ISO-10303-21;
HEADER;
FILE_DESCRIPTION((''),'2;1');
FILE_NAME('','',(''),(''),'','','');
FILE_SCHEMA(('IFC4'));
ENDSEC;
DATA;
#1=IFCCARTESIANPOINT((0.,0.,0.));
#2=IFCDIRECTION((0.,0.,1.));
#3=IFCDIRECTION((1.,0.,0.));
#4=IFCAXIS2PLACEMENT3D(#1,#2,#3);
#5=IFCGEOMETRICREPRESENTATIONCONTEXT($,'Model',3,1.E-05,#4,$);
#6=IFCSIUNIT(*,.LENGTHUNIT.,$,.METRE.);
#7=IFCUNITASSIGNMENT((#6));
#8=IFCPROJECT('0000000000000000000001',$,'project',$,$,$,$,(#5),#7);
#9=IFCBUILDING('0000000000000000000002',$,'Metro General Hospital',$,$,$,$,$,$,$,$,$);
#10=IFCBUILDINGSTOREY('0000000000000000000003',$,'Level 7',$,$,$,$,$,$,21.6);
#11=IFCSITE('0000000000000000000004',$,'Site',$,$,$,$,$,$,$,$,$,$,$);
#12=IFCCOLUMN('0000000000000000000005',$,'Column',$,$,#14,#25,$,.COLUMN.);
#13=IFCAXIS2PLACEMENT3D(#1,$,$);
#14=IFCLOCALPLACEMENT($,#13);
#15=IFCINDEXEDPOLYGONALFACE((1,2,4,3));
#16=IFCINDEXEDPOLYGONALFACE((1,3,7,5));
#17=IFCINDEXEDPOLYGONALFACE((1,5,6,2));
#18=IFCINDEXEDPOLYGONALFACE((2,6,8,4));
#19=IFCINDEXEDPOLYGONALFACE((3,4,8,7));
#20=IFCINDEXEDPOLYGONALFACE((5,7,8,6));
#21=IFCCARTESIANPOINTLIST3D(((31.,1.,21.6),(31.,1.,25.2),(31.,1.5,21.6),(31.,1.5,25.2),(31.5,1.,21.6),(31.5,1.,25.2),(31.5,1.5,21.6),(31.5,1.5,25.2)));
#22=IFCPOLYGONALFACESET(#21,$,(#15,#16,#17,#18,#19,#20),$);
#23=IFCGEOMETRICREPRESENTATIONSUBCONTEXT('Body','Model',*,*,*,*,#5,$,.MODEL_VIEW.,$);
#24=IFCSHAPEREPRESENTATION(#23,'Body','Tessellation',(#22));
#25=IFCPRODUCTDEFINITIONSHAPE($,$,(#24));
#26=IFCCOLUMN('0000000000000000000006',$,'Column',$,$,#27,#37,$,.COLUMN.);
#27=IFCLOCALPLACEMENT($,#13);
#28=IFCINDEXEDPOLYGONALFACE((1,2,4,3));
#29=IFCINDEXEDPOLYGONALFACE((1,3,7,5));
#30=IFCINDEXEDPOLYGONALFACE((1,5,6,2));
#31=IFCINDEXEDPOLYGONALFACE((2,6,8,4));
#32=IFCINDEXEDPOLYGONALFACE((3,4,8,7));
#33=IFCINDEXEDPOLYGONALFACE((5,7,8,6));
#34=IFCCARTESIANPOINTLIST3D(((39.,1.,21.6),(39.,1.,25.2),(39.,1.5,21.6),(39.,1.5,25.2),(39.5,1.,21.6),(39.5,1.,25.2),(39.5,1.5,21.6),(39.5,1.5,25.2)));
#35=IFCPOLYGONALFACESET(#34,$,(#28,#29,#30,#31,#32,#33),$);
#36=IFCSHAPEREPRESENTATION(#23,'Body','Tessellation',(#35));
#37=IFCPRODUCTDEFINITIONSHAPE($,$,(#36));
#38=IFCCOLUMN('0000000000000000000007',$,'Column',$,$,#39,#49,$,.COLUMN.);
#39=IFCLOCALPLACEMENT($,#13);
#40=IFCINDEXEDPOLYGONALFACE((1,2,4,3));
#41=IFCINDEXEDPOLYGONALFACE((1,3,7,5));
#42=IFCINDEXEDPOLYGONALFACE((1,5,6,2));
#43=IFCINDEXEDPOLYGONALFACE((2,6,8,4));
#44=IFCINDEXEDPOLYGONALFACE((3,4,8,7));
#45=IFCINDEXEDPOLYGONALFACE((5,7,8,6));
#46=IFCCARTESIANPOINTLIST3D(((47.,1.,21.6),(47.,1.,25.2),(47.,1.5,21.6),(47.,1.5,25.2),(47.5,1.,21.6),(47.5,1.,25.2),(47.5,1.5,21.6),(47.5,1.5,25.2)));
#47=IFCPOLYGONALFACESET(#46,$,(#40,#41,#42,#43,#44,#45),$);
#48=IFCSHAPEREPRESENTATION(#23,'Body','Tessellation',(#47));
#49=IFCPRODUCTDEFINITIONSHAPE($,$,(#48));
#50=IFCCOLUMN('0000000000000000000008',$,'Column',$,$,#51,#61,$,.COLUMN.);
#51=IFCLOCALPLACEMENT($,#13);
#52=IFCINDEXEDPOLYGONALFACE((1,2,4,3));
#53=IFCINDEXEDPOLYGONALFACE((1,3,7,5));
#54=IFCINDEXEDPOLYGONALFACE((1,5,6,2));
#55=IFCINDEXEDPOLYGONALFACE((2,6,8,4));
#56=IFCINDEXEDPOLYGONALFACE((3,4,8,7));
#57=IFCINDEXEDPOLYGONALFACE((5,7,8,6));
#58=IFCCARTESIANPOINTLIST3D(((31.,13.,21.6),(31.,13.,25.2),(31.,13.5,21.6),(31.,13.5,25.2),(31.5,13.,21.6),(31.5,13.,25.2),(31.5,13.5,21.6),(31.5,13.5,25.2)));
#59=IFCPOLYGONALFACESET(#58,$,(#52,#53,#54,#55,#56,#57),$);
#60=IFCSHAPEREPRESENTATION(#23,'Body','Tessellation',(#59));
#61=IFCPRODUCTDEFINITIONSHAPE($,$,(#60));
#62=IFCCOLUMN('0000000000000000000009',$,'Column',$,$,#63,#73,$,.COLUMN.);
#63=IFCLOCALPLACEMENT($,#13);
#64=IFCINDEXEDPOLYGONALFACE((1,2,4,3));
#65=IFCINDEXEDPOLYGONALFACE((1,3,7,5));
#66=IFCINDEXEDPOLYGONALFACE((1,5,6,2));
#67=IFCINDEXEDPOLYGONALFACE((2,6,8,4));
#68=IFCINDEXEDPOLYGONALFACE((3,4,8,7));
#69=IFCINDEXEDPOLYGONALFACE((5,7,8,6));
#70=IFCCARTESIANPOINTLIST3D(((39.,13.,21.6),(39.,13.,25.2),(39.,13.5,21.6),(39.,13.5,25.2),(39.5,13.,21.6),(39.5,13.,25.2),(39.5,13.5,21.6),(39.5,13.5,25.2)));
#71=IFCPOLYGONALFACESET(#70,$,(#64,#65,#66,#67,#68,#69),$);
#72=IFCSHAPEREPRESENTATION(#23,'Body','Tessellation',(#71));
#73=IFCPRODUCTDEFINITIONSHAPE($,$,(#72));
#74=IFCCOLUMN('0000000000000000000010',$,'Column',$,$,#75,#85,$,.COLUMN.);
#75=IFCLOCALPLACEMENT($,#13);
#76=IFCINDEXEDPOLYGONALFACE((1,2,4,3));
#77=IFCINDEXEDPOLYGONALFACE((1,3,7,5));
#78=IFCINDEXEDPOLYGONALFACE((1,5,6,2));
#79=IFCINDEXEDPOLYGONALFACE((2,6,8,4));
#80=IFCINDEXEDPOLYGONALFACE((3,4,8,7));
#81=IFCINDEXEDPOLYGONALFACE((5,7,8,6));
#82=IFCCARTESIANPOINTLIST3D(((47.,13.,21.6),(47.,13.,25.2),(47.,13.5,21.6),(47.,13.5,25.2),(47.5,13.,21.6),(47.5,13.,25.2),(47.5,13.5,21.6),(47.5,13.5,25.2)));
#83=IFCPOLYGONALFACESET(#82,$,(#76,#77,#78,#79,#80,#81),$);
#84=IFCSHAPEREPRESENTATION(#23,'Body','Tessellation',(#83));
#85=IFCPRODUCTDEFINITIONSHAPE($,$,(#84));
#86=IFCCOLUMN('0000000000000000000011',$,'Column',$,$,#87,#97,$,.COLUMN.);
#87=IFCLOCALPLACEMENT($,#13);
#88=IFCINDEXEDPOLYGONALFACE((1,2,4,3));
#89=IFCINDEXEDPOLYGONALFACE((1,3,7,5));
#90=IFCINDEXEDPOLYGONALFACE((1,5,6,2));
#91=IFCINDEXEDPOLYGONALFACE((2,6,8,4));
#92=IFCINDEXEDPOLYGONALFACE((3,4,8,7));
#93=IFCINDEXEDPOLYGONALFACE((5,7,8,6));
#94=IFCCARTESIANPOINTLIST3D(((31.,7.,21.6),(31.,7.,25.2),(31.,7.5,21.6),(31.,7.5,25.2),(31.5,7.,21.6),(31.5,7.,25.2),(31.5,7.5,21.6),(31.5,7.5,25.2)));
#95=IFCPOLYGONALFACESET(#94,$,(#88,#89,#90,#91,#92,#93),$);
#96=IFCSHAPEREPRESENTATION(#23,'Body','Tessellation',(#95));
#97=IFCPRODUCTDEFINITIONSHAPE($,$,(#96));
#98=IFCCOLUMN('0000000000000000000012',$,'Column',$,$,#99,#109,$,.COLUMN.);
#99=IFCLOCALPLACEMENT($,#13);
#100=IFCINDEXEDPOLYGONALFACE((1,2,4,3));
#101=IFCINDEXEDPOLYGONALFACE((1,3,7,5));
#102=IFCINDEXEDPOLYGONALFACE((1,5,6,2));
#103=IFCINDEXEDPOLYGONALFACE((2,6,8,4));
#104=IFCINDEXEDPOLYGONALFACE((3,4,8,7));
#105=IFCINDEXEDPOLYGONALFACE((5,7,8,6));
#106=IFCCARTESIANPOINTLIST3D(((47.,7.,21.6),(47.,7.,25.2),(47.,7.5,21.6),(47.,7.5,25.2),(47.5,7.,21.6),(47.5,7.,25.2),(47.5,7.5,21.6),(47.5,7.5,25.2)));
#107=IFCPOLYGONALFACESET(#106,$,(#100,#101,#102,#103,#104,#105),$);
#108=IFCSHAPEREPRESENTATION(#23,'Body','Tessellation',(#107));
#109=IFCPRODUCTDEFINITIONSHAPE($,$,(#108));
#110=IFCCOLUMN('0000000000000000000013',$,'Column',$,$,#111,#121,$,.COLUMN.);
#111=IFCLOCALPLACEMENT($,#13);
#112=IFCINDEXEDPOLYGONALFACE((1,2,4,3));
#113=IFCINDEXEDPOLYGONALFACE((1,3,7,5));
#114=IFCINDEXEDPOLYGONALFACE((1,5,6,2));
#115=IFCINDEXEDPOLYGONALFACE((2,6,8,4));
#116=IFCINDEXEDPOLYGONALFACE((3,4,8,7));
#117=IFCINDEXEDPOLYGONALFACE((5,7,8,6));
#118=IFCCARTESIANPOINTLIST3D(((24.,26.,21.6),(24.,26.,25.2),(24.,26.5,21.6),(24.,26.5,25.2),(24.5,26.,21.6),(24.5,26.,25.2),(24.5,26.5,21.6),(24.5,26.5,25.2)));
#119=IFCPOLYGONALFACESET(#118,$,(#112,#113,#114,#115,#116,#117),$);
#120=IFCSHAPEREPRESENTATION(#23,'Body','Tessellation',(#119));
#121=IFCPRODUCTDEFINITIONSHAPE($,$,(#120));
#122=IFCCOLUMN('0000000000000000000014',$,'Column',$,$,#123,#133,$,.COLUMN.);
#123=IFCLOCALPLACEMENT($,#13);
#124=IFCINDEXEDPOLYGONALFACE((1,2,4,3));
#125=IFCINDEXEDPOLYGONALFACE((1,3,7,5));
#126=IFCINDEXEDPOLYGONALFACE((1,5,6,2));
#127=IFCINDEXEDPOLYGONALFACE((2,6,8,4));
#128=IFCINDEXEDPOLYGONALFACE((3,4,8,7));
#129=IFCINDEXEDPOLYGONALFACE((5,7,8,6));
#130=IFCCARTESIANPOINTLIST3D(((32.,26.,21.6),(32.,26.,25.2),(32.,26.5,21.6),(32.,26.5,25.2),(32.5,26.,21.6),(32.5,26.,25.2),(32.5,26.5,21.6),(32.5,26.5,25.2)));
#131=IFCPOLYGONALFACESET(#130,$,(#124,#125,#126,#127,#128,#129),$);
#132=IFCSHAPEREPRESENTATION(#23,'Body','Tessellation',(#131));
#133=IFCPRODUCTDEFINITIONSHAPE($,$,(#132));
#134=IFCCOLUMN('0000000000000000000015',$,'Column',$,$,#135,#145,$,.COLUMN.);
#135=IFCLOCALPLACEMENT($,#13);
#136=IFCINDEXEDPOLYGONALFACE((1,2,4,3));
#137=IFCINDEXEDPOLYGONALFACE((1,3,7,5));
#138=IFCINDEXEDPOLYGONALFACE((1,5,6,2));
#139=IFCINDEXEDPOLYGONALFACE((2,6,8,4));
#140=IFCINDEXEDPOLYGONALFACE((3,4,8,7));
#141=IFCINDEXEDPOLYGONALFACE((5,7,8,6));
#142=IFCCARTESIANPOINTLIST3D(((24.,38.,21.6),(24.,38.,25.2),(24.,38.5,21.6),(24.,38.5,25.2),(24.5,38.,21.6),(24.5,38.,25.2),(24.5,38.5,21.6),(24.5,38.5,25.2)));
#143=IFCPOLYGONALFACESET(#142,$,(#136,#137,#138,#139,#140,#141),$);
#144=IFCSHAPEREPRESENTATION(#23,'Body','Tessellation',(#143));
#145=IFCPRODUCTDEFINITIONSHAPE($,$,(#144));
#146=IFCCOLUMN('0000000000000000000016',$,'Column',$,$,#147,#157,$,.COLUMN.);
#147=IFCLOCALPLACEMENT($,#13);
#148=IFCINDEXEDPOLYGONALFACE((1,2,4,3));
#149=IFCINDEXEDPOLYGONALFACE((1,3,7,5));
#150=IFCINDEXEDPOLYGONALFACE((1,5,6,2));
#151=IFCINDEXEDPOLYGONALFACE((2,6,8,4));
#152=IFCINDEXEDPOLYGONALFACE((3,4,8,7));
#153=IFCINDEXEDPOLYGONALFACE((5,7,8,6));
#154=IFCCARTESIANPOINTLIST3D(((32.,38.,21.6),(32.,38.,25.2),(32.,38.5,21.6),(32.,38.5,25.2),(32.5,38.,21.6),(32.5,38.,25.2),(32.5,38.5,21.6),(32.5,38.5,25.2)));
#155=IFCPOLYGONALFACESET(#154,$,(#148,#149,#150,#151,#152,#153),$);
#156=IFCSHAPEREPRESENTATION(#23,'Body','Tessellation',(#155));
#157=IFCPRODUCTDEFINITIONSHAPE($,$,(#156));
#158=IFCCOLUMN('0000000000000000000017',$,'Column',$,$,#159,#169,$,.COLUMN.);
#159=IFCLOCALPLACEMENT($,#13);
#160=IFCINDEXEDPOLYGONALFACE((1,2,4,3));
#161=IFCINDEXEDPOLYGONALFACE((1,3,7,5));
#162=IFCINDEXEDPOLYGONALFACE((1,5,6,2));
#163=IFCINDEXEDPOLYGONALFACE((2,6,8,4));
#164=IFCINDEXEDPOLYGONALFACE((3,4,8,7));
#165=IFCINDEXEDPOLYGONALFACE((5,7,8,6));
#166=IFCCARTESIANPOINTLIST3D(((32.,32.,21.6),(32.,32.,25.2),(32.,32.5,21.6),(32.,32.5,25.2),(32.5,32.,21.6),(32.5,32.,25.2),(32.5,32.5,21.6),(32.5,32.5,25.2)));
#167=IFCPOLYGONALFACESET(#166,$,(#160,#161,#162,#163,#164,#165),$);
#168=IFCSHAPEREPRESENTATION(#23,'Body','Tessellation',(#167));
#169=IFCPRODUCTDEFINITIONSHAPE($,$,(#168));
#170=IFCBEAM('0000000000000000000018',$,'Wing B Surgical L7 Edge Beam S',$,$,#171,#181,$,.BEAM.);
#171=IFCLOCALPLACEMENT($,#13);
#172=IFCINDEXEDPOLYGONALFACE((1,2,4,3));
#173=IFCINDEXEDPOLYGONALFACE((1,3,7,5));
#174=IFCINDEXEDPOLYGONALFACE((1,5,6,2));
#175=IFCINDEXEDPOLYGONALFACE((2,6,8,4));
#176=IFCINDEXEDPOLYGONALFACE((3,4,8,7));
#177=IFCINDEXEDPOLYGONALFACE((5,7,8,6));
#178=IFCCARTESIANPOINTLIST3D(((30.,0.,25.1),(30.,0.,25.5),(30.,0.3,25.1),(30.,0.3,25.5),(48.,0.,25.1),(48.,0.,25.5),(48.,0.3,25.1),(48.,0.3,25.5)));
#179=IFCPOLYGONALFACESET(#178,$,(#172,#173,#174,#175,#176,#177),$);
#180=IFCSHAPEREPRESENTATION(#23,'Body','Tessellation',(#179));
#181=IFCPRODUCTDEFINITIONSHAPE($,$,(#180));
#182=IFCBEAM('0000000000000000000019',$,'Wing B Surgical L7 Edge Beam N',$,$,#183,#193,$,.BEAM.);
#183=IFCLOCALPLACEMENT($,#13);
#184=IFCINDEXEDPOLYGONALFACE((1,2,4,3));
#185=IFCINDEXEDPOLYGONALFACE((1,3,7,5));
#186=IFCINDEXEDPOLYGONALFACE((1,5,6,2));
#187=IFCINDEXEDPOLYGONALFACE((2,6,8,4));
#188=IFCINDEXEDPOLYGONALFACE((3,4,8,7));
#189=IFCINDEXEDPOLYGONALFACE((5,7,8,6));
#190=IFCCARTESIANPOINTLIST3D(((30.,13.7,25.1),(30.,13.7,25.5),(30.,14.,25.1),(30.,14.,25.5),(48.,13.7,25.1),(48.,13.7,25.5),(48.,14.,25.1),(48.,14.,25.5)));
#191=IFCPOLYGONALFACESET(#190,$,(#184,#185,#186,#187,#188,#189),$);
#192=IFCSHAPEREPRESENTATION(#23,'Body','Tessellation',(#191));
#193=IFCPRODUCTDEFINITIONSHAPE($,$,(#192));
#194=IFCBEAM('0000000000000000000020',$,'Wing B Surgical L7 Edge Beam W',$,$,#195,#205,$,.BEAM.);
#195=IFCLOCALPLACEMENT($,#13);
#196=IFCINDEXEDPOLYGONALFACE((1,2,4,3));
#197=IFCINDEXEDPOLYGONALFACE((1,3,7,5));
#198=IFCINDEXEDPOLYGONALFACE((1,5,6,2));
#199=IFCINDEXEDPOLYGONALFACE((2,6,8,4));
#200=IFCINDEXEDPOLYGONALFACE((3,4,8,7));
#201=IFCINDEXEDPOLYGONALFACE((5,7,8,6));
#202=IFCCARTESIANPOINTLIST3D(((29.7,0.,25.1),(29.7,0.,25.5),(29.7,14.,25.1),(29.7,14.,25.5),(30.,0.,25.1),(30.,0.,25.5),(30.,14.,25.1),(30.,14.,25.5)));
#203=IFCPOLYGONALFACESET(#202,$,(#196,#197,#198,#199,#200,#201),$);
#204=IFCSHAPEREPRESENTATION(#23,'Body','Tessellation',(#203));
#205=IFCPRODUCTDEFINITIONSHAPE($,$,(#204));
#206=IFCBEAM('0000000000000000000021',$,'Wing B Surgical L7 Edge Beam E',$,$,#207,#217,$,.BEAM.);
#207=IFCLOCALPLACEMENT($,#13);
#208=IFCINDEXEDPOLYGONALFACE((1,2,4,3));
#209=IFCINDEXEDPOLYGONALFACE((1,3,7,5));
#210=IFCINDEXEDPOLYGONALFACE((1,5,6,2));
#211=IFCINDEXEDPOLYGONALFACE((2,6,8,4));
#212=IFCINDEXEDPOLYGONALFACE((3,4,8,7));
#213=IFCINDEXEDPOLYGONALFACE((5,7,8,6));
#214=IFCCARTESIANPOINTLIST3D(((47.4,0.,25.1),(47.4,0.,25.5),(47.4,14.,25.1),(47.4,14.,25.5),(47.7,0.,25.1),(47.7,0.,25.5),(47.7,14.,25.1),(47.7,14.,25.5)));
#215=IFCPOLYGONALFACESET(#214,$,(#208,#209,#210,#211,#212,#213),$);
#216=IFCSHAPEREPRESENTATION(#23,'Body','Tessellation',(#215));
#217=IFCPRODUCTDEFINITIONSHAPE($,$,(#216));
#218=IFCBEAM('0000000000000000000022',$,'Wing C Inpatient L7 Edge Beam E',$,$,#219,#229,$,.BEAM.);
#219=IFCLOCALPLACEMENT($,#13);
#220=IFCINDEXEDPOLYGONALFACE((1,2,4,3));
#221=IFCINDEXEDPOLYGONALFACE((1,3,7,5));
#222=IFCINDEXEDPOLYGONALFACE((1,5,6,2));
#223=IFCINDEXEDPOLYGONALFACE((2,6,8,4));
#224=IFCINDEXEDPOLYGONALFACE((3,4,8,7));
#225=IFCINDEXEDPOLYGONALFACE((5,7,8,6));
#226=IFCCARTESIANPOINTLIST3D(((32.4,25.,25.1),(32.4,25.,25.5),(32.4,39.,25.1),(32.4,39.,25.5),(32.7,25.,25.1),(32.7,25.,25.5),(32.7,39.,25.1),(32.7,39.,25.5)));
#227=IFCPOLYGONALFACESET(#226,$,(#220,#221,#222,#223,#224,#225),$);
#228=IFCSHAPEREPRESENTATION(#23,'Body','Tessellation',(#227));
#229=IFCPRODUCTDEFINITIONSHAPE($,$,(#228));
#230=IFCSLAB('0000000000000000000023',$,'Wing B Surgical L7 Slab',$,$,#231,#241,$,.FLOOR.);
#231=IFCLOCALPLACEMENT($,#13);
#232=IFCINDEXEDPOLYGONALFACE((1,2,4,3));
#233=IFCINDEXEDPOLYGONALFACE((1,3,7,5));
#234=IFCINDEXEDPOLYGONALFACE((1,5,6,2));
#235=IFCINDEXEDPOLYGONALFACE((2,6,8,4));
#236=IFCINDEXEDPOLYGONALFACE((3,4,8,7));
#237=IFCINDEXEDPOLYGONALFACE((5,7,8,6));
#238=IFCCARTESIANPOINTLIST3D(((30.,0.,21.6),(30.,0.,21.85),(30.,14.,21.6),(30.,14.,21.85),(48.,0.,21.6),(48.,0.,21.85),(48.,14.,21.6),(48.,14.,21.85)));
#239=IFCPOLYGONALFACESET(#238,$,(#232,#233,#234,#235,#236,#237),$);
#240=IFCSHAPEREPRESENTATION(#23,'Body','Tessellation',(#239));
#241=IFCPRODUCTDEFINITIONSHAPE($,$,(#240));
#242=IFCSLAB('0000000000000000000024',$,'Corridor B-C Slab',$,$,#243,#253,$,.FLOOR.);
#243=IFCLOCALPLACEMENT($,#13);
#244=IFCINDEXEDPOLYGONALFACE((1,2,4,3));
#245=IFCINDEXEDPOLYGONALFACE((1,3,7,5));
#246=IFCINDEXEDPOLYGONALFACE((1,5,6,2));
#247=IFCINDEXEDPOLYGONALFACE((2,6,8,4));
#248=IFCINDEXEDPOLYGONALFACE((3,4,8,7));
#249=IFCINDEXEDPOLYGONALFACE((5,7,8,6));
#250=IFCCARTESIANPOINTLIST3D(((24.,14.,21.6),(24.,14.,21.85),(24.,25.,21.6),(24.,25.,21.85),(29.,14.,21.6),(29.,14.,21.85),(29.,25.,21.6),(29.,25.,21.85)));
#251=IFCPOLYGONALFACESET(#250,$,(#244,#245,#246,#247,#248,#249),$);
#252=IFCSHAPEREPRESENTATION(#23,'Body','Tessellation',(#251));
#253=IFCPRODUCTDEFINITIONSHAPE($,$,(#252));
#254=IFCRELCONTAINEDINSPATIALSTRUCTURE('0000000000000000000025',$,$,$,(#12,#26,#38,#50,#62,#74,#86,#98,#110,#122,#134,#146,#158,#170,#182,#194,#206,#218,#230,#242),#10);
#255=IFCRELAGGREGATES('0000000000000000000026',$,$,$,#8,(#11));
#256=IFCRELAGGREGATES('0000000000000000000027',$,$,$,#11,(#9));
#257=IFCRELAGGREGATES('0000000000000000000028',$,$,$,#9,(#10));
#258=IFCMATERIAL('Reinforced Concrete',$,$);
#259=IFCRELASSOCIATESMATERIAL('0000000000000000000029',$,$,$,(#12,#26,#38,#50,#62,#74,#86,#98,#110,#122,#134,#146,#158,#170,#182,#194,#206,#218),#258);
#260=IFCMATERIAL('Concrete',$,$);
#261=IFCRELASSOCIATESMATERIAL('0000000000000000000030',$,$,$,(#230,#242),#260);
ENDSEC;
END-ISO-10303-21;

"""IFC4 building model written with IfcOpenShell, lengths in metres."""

from ifc_helpers import new_model, si_unit, frame, origin_with_axes, place, context, subcontext, project, spatial, line, indexed_curve, outline, extrude, material, element, save


model = new_model("IFC4")

# Units and contexts
model_context = context("Model", 3, precision=1e-05, world=origin_with_axes())
body_context = subcontext(model_context, "Body", "Model", "MODEL_VIEW")
ifc_project = project(units=[si_unit("LENGTHUNIT", "METRE")], contexts=[model_context])

# Site, building, storey
site = spatial("IfcSite", under=ifc_project, Name="Site")
building = spatial("IfcBuilding", under=site, Name="Metro General Hospital")
storey = spatial("IfcBuildingStorey", under=building, Name="Level 7", Elevation=21.6)

# Columns
ifc_material_1 = material(Name="Reinforced Concrete")
for number, where, z_axis, x_axis, name in (
    (1, (31.0, 1.0, 21.6), (0.0, 0.0, 1.0), (1.0, 0.0, 0.0), "Column"),
    (2, (39.0, 1.0, 21.6), (0.0, 0.0, 1.0), (1.0, 0.0, 0.0), "Column"),
    (3, (47.0, 1.0, 21.6), (0.0, 0.0, 1.0), (1.0, 0.0, 0.0), "Column"),
    (4, (31.0, 13.0, 21.6), (0.0, 0.0, 1.0), (1.0, 0.0, 0.0), "Column"),
    (5, (39.0, 13.0, 21.6), (0.0, 0.0, 1.0), (1.0, 0.0, 0.0), "Column"),
    (6, (47.0, 13.0, 21.6), (0.0, 0.0, 1.0), (1.0, 0.0, 0.0), "Column"),
    (7, (31.0, 7.0, 21.6), (0.0, 0.0, 1.0), (1.0, 0.0, 0.0), "Column"),
    (8, (47.0, 7.0, 21.6), (0.0, 0.0, 1.0), (1.0, 0.0, 0.0), "Column"),
    (9, (24.0, 26.0, 21.6), (0.0, 0.0, 1.0), (1.0, 0.0, 0.0), "Column"),
    (10, (32.0, 26.0, 21.6), (0.0, 0.0, 1.0), (1.0, 0.0, 0.0), "Column"),
    (11, (24.0, 38.0, 21.6), (0.0, 0.0, 1.0), (1.0, 0.0, 0.0), "Column"),
    (12, (32.0, 38.0, 21.6), (0.0, 0.0, 1.0), (1.0, 0.0, 0.0), "Column"),
    (13, (32.0, 32.0, 21.6), (0.0, 0.0, 1.0), (1.0, 0.0, 0.0), "Column"),
):
    element("IfcColumn", number, at=place(None, frame(where, z_axis=z_axis, x_axis=x_axis)), inside=storey, material=ifc_material_1, Name=name, PredefinedType="COLUMN", context=body_context, shape_type="SweptSolid", body=[
        extrude(outline(indexed_curve([(0.0, 0.0), (0.5, 0.0), (0.5, 0.5), (0.0, 0.5)], segments=[line(1, 2, 3, 4, 1)])), origin_with_axes(), (0.0, 0.0, 1.0), 3.6),
    ])

# Beams
for number, where, z_axis, x_axis, name in (
    (14, (30.0, 0.0, 25.1), (0.0, 0.0, 1.0), (1.0, 0.0, 0.0), "Wing B Surgical L7 Edge Beam S"),
    (15, (30.0, 13.7, 25.1), (0.0, 0.0, 1.0), (1.0, 0.0, 0.0), "Wing B Surgical L7 Edge Beam N"),
):
    element("IfcBeam", number, at=place(None, frame(where, z_axis=z_axis, x_axis=x_axis)), inside=storey, material=ifc_material_1, Name=name, PredefinedType="BEAM", context=body_context, shape_type="SweptSolid", body=[
        extrude(outline(indexed_curve([(0.0, 0.0), (18.0, 0.0), (18.0, 0.3), (0.0, 0.3)], segments=[line(1, 2, 3, 4, 1)])), origin_with_axes(), (0.0, 0.0, 1.0), 0.4),
    ])
for number, where, z_axis, x_axis, name in (
    (16, (30.0, 0.0, 25.1), (0.0, 0.0, 1.0), (0.0, 1.0, 0.0), "Wing B Surgical L7 Edge Beam W"),
    (17, (47.7, 0.0, 25.1), (0.0, 0.0, 1.0), (0.0, 1.0, 0.0), "Wing B Surgical L7 Edge Beam E"),
    (18, (32.7, 25.0, 25.1), (0.0, 0.0, 1.0), (0.0, 1.0, 0.0), "Wing C Inpatient L7 Edge Beam E"),
):
    element("IfcBeam", number, at=place(None, frame(where, z_axis=z_axis, x_axis=x_axis)), inside=storey, material=ifc_material_1, Name=name, PredefinedType="BEAM", context=body_context, shape_type="SweptSolid", body=[
        extrude(outline(indexed_curve([(0.0, 0.0), (14.0, 0.0), (14.0, 0.3), (0.0, 0.3)], segments=[line(1, 2, 3, 4, 1)])), origin_with_axes(), (0.0, 0.0, 1.0), 0.4),
    ])

# Slabs
ifc_material_2 = material(Name="Concrete")
slab_1_placement = place(None, frame((30.0, 0.0, 21.6), z_axis=(0.0, 0.0, 1.0), x_axis=(1.0, 0.0, 0.0)))
element("IfcSlab", 19, at=slab_1_placement, inside=storey, material=ifc_material_2, Name="Wing B Surgical L7 Slab", PredefinedType="FLOOR", context=body_context, shape_type="SweptSolid", body=[
    extrude(outline(indexed_curve([(0.0, 0.0), (18.0, 0.0), (18.0, 14.0), (0.0, 14.0)], segments=[line(1, 2, 3, 4, 1)])), origin_with_axes(), (0.0, 0.0, 1.0), 0.25),
])
slab_2_placement = place(None, frame((24.0, 14.0, 21.6), z_axis=(0.0, 0.0, 1.0), x_axis=(1.0, 0.0, 0.0)))
element("IfcSlab", 20, at=slab_2_placement, inside=storey, material=ifc_material_2, Name="Corridor B-C Slab", PredefinedType="FLOOR", context=body_context, shape_type="SweptSolid", body=[
    extrude(outline(indexed_curve([(0.0, 0.0), (5.0, 0.0), (5.0, 11.0), (0.0, 11.0)], segments=[line(1, 2, 3, 4, 1)])), origin_with_axes(), (0.0, 0.0, 1.0), 0.25),
])

save(model, "model.ifc")
